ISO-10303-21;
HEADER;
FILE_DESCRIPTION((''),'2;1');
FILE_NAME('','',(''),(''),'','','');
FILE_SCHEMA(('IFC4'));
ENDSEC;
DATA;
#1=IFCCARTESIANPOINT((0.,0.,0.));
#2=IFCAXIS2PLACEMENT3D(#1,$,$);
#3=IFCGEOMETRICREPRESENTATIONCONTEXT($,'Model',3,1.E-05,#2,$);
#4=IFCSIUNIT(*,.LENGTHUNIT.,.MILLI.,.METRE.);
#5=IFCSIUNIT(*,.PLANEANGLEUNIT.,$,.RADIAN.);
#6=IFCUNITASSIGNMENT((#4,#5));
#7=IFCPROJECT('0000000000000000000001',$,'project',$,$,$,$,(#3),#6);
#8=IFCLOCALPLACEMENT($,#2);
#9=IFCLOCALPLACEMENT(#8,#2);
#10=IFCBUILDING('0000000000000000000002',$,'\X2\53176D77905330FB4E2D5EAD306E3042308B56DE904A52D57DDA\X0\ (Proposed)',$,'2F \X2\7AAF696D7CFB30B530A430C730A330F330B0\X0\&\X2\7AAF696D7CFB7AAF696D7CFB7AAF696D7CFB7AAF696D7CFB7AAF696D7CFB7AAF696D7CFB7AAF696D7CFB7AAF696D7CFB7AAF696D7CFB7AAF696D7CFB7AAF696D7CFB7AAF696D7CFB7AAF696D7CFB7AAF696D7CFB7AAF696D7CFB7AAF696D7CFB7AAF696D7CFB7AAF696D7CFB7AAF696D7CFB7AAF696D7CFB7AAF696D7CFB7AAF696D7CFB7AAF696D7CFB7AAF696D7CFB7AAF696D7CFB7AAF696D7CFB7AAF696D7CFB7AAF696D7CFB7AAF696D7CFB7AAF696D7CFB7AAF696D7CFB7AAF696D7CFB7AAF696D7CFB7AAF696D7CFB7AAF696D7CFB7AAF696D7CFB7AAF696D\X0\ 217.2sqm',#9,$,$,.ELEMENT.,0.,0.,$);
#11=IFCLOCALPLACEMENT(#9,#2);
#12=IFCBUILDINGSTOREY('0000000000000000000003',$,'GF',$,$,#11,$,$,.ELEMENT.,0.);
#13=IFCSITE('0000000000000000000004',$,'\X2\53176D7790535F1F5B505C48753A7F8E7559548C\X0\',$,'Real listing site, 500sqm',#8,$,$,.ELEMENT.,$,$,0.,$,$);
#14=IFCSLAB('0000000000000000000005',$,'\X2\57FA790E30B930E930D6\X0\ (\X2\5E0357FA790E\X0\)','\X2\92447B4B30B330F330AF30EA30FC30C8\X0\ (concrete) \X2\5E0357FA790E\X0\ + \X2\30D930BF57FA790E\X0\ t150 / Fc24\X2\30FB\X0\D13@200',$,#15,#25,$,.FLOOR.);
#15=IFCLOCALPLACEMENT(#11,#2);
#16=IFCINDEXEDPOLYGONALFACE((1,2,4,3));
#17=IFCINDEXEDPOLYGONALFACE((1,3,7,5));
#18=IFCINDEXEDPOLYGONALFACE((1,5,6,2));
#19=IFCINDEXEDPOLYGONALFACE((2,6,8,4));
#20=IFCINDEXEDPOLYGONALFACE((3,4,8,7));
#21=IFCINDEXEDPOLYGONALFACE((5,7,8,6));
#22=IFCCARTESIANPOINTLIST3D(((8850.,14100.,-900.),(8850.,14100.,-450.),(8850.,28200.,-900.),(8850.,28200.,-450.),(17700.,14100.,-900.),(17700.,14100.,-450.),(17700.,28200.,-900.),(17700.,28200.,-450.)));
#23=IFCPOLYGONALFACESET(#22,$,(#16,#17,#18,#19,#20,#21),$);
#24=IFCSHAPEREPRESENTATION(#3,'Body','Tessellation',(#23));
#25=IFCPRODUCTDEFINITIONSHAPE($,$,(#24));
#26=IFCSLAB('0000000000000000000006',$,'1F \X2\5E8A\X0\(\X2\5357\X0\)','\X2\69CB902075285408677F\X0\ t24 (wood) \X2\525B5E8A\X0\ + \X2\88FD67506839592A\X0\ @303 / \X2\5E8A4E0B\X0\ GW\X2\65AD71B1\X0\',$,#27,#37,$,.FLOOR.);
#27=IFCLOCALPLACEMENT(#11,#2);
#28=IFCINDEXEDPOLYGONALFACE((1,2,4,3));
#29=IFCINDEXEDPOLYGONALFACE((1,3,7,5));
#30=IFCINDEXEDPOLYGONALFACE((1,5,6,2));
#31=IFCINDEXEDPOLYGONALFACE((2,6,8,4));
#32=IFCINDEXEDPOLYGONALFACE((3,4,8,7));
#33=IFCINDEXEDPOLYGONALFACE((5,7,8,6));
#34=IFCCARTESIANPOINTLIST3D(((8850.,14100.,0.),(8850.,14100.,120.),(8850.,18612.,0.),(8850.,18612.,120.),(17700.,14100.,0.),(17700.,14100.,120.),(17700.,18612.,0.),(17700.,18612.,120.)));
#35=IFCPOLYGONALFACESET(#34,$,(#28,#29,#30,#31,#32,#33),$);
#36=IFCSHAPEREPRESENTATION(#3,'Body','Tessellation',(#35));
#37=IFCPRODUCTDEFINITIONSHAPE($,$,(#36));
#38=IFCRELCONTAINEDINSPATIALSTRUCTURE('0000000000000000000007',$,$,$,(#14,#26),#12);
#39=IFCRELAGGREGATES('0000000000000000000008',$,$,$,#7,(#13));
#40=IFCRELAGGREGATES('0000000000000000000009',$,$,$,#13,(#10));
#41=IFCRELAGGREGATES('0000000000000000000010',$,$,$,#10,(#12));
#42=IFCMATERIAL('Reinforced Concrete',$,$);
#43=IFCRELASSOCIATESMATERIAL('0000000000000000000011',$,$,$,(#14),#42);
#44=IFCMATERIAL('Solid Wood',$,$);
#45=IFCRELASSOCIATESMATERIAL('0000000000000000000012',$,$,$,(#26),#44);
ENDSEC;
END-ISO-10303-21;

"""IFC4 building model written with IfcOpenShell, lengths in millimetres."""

from ifc_helpers import new_model, si_unit, frame, frame_2d, origin, place, context, project, spatial, rectangle, extrude, material, element, save


model = new_model("IFC4")

# Units and contexts
model_context = context("Model", 3, precision=1e-05, world=origin())
ifc_project = project(units=[si_unit("LENGTHUNIT", "METRE", prefix="MILLI"), si_unit("PLANEANGLEUNIT", "RADIAN")], contexts=[model_context])

# Site, building, storey
site_placement = place(None, origin())
site = spatial("IfcSite", under=ifc_project, at=site_placement, Name="北海道弟子屈町美留和", ObjectType="Real listing site, 500sqm", CompositionType="ELEMENT", RefElevation=0.0)
building_placement = place(site_placement, origin())
building = spatial("IfcBuilding", under=site, at=building_placement, Name="北海道・中庭のある回遊動線 (Proposed)", ObjectType="2F 窯業系サイディング&窯業系窯業系窯業系窯業系窯業系窯業系窯業系窯業系窯業系窯業系窯業系窯業系窯業系窯業系窯業系窯業系窯業系窯業系窯業系窯業系窯業系窯業系窯業系窯業系窯業系窯業系窯業系窯業系窯業系窯業系窯業系窯業系窯業系窯業系窯業系窯業系窯業 217.2sqm", CompositionType="ELEMENT", ElevationOfRefHeight=0.0, ElevationOfTerrain=0.0)
storey_placement = place(building_placement, origin())
storey = spatial("IfcBuildingStorey", under=building, at=storey_placement, Name="GF", CompositionType="ELEMENT", Elevation=0.0)

# Shared definitions
ifc_material_1 = material(Name="Solid Wood")

# Slabs
ifc_material_2 = material(Name="Reinforced Concrete")
slab_1_placement = place(storey_placement, frame((4425.0, 7050.0, -450.0)))
element("IfcSlab", 1, at=slab_1_placement, inside=storey, material=ifc_material_2, Name="基礎スラブ (布基礎)", Description="鉄筋コンクリート (concrete) 布基礎 + ベタ基礎 t150 / Fc24・D13@200", PredefinedType="FLOOR", context=model_context, shape_type="SweptSolid", body=[
    extrude(rectangle(XDim=8850.0, YDim=14100.0, at=frame_2d((4425.0, 7050.0))), frame((4425.0, 7050.0, -450.0)), (0.0, 0.0, 1.0), 450.0),
])
slab_2_placement = place(storey_placement, frame((4425.0, 7050.0, 0.0)))
element("IfcSlab", 2, at=slab_2_placement, inside=storey, material=ifc_material_1, Name="1F 床(南)", Description="構造用合板 t24 (wood) 剛床 + 製材根太 @303 / 床下 GW断熱", PredefinedType="FLOOR", context=model_context, shape_type="SweptSolid", body=[
    extrude(rectangle(XDim=8850.0, YDim=4512.0, at=frame_2d((4425.0, 2256.0))), frame((4425.0, 7050.0, 0.0)), (0.0, 0.0, 1.0), 120.0),
])

save(model, "model.ifc")
